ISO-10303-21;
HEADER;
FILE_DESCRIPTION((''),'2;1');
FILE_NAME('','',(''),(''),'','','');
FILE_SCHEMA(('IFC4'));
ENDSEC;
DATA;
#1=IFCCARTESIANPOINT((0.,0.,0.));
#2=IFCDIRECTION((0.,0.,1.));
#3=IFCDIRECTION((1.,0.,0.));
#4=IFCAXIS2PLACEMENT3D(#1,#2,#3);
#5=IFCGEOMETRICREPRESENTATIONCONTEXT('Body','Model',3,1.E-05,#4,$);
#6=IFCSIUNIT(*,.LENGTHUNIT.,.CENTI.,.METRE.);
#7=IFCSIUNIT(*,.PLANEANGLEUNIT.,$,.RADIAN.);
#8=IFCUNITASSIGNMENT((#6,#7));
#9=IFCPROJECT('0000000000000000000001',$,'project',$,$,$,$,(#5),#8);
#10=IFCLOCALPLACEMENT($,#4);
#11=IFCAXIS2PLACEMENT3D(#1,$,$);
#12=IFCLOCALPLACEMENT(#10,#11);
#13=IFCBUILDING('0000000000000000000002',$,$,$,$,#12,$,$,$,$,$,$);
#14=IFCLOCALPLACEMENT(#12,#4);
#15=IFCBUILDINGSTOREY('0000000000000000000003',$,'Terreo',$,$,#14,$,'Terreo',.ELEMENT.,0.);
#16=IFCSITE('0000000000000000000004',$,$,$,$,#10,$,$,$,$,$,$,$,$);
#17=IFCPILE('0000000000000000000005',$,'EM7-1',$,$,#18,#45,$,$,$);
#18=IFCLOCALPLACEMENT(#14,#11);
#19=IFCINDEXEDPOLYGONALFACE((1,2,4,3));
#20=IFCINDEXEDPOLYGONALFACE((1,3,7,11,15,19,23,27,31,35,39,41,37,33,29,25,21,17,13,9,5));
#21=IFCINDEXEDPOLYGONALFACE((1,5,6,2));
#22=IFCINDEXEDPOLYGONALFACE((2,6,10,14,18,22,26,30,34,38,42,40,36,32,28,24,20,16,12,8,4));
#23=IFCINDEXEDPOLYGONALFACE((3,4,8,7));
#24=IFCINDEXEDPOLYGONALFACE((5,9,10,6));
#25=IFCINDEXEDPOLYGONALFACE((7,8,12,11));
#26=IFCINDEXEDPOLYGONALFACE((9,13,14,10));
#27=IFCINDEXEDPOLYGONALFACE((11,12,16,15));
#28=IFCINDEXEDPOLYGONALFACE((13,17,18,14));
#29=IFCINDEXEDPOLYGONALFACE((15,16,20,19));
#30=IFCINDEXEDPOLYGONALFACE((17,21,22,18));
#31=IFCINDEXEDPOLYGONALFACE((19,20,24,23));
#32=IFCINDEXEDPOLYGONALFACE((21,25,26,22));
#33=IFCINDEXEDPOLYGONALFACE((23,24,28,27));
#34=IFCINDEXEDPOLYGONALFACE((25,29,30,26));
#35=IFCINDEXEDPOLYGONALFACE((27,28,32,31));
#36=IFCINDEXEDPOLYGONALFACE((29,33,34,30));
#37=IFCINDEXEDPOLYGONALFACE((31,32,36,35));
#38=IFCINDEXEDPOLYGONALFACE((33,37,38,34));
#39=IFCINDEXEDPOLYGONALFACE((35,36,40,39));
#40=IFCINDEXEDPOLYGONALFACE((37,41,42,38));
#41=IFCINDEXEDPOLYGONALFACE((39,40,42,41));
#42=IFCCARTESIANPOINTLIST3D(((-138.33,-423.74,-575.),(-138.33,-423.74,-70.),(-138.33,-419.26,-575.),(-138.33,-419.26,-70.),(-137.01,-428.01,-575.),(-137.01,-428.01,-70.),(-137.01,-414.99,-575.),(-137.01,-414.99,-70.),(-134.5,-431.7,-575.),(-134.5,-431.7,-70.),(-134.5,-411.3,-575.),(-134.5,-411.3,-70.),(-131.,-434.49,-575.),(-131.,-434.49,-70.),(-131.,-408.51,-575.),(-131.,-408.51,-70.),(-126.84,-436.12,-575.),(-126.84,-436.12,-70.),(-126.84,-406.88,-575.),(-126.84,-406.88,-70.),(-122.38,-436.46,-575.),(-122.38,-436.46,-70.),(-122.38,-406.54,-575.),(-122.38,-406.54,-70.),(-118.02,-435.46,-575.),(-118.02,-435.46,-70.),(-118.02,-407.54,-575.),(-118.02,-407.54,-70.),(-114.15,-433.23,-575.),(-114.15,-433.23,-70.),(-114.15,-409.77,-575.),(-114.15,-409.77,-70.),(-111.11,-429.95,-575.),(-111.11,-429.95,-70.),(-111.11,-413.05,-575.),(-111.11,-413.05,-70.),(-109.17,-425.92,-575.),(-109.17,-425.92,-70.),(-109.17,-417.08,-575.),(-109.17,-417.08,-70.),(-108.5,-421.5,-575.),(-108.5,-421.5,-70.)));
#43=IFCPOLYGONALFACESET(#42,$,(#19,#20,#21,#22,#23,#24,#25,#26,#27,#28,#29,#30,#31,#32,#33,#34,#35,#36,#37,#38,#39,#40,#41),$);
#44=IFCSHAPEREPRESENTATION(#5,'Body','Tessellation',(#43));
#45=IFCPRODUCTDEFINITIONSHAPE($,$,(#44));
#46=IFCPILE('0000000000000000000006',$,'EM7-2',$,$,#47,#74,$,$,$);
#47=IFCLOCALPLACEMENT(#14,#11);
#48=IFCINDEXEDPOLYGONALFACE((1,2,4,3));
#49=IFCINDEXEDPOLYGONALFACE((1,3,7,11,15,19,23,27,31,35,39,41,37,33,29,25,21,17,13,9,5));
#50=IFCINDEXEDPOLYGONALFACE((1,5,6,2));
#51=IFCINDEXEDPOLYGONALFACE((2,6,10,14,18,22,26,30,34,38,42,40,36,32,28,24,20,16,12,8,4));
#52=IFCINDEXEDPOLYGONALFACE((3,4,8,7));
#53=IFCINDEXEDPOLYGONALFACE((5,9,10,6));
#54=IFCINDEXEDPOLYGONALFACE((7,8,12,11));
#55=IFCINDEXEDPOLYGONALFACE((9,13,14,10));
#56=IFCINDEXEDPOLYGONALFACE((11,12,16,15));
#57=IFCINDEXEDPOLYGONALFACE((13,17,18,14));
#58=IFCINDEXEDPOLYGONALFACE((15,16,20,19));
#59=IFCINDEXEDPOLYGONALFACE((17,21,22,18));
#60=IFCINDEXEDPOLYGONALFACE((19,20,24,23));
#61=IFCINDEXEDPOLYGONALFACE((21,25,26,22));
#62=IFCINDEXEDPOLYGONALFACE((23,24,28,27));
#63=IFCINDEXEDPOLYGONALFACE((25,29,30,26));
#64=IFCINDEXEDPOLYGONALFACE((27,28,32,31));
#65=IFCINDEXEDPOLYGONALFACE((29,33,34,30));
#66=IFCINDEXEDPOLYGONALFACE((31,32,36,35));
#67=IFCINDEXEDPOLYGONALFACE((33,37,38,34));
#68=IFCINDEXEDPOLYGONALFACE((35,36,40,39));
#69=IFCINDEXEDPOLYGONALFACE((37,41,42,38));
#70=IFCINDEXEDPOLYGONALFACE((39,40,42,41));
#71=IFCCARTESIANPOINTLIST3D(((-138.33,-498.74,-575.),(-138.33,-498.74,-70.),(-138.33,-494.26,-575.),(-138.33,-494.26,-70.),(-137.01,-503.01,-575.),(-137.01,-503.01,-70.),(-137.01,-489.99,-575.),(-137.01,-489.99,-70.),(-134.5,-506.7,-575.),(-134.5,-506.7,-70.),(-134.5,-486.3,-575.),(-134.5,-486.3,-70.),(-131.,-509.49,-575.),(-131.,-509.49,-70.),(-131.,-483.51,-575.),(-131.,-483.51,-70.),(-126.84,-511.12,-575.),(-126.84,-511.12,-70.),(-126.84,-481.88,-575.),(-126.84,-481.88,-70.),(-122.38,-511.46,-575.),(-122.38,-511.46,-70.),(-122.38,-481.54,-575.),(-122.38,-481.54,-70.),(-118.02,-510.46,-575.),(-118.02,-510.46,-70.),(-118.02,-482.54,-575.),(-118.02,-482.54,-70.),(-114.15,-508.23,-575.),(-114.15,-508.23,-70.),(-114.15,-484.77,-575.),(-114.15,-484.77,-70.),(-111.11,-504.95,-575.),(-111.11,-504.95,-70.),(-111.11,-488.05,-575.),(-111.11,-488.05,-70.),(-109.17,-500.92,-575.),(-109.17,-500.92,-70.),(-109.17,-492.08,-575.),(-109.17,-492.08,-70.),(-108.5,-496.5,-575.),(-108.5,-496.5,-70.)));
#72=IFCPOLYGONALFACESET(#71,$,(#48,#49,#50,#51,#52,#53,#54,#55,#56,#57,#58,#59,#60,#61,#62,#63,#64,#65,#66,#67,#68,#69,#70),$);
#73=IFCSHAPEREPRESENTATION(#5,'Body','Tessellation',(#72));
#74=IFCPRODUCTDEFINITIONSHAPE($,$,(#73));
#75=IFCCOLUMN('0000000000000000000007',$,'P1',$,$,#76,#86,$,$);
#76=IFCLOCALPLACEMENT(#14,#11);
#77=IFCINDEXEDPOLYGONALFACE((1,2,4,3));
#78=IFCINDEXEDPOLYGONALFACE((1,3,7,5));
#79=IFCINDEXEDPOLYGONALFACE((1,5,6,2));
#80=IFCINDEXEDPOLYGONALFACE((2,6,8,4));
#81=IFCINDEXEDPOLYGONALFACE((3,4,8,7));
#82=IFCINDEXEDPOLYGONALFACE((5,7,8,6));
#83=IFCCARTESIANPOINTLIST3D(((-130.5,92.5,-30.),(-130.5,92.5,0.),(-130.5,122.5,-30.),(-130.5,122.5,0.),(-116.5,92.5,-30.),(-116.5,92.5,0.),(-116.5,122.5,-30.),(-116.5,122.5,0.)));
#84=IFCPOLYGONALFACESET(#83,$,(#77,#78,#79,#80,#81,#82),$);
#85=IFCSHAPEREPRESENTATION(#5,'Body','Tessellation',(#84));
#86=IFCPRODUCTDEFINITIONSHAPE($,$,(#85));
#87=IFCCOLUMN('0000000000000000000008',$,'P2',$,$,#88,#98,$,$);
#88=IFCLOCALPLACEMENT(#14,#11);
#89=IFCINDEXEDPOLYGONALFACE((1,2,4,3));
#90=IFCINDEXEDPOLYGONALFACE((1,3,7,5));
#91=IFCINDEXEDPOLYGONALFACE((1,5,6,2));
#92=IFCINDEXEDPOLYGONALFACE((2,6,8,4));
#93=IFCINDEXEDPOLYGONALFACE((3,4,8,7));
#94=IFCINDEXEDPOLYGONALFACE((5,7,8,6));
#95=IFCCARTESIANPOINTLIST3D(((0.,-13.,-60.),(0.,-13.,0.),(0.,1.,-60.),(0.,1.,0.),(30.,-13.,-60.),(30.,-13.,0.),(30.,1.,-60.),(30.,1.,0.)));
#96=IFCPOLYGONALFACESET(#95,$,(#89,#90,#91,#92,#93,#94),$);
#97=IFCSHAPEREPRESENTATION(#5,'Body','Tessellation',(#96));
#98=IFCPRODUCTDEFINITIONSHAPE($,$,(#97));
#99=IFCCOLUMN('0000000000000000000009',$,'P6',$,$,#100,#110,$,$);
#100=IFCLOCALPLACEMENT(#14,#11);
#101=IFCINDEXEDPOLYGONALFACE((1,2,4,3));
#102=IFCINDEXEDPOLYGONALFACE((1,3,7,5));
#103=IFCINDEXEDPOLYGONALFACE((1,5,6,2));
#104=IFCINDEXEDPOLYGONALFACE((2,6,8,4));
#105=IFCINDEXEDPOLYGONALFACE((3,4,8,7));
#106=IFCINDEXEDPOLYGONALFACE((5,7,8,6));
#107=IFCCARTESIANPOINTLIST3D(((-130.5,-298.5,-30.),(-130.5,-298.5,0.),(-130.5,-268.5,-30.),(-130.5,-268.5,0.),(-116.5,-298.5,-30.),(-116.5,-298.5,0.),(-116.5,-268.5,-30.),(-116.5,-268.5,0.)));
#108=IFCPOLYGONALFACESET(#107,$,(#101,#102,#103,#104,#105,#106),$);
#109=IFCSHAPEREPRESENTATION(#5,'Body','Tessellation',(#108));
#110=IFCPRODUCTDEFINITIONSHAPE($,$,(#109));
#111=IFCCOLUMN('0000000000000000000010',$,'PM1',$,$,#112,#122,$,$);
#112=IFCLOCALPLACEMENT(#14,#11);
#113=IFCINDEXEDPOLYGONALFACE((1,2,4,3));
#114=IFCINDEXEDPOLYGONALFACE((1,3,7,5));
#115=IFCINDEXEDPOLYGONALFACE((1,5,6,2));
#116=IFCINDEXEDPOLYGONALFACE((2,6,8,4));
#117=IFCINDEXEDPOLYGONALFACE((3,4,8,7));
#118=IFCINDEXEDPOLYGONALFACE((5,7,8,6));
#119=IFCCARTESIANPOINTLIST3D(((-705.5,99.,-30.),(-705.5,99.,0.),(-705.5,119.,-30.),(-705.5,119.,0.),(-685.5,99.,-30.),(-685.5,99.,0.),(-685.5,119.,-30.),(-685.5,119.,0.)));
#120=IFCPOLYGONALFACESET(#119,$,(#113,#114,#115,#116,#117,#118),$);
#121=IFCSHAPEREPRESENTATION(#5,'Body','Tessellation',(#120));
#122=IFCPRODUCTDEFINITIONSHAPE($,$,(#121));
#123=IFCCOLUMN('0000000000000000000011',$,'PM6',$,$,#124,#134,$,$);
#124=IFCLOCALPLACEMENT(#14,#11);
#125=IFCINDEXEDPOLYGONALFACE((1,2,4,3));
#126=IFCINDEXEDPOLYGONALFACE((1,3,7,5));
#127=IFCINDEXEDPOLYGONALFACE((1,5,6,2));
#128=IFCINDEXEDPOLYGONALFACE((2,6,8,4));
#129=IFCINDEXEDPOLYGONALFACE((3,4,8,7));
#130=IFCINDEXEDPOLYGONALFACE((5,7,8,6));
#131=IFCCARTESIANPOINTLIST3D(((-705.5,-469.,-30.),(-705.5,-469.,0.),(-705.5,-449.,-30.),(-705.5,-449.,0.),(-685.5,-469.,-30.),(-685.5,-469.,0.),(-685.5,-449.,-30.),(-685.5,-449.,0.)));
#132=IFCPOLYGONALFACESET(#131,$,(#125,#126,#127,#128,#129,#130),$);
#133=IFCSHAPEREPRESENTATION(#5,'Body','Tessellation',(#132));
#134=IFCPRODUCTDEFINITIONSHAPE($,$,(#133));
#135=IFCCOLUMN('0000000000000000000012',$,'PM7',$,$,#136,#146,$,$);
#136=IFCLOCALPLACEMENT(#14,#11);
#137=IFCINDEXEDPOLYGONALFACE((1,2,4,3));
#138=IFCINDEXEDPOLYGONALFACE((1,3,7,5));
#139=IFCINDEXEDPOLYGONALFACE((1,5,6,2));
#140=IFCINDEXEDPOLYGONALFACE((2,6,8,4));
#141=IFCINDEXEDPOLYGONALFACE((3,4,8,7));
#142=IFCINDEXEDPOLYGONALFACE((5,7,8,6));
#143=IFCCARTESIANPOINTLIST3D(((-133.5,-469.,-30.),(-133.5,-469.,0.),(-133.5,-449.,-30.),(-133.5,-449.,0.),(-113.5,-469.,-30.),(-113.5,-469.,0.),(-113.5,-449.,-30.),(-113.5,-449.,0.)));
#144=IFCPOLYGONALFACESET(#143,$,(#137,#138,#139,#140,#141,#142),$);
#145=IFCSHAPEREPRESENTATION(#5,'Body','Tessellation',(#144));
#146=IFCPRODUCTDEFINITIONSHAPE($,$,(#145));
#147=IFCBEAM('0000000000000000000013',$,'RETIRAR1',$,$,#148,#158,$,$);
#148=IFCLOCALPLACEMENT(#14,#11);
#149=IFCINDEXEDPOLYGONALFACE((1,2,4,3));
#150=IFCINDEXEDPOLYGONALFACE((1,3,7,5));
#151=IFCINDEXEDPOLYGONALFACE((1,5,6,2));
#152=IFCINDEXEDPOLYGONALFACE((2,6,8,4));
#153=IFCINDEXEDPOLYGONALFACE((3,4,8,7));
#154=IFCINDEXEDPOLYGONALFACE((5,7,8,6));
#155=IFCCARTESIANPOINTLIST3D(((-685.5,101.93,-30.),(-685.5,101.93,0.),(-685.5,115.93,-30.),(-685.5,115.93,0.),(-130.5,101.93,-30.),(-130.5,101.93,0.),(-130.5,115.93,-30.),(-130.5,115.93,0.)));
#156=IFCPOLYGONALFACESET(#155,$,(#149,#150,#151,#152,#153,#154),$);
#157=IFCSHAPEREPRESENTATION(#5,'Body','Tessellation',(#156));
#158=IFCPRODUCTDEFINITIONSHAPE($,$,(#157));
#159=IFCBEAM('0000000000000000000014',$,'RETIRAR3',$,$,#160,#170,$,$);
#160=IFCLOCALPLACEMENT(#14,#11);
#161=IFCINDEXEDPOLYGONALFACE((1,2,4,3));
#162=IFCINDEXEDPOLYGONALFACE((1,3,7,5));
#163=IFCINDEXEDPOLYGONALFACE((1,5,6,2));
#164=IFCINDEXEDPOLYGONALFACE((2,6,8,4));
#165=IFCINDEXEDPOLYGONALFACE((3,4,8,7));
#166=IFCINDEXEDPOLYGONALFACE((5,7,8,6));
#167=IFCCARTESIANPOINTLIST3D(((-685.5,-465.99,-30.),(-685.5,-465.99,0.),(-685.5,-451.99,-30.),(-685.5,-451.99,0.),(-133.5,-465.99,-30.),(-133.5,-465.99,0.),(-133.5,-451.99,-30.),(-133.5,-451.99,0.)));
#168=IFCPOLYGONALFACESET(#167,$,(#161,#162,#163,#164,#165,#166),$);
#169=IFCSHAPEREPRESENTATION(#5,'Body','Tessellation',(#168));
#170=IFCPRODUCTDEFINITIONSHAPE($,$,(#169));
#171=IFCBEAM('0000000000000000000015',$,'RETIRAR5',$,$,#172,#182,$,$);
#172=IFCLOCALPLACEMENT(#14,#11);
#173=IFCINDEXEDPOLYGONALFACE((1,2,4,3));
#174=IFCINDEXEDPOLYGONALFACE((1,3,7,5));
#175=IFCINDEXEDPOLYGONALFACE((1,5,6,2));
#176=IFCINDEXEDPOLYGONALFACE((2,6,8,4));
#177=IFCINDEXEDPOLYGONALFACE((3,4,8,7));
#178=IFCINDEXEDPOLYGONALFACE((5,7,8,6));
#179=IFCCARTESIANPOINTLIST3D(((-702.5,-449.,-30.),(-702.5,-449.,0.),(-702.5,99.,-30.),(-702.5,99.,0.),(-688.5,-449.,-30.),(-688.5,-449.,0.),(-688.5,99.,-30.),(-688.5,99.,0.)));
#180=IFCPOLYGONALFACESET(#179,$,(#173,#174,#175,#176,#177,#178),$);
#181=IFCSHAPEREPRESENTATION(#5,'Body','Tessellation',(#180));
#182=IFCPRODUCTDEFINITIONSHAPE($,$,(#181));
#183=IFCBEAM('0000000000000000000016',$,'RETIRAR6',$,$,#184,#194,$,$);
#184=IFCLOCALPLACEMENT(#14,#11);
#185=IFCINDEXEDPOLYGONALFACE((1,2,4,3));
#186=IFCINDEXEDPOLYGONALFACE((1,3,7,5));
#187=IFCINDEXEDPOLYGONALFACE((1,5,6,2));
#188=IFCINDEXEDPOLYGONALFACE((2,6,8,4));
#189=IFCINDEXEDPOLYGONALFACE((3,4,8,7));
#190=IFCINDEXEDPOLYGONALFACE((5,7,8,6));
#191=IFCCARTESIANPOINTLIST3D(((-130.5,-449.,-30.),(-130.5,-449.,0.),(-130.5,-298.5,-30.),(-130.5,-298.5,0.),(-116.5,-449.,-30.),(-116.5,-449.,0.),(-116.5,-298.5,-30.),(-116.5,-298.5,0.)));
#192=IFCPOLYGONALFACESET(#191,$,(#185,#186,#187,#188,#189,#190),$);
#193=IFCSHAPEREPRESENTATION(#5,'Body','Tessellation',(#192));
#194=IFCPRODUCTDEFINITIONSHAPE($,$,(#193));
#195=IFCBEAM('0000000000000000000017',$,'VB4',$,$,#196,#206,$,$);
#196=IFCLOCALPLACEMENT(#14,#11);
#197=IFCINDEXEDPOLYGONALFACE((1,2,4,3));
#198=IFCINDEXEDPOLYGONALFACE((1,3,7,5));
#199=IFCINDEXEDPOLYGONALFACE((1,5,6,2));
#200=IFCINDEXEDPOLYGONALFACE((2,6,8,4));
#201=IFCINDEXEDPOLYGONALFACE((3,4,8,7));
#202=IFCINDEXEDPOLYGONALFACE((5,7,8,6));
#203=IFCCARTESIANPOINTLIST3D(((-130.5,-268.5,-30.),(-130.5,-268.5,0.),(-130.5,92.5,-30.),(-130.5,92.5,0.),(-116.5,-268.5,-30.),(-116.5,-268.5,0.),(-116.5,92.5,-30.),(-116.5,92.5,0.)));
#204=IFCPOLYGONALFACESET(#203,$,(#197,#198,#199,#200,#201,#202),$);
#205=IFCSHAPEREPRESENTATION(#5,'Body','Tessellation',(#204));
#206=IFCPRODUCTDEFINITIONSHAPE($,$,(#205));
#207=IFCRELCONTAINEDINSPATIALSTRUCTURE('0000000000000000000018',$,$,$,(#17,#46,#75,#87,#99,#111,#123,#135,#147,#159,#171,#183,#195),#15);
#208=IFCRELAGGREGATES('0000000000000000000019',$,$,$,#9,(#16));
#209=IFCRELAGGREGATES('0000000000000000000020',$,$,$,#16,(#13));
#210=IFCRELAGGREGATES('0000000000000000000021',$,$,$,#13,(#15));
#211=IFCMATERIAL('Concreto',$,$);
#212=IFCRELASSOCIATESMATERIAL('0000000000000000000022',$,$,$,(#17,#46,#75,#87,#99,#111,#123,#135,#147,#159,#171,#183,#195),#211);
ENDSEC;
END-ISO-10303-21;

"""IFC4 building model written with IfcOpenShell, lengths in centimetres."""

from ifc_helpers import new_model, si_unit, frame, origin, origin_with_axes, origin_2d_with_axis, place, context, project, spatial, rectangle, circle, extrude, material, element, save


model = new_model("IFC4")

# Units and contexts
model_context = context("Model", 3, precision=1e-05, world=origin_with_axes(), identifier="Body")
ifc_project = project(units=[si_unit("LENGTHUNIT", "METRE", prefix="CENTI"), si_unit("PLANEANGLEUNIT", "RADIAN")], contexts=[model_context])

# Site, building, storey
site_placement = place(None, origin_with_axes())
site = spatial("IfcSite", under=ifc_project, at=site_placement)
building_placement = place(site_placement, origin())
building = spatial("IfcBuilding", under=site, at=building_placement)
storey_placement = place(building_placement, origin_with_axes())
storey = spatial("IfcBuildingStorey", under=building, at=storey_placement, Name="Terreo", LongName="Terreo", CompositionType="ELEMENT", Elevation=0.0)

# Piles
ifc_material = material(Name="Concreto")
for number, where, z_axis, x_axis, name in (
    (1, (-123.5, -421.5, -70.0), (0.0, 0.0, 1.0), (1.0, 0.0, 0.0), "EM7-1"),
    (2, (-123.5, -496.5, -70.0), (0.0, 0.0, 1.0), (1.0, 0.0, 0.0), "EM7-2"),
):
    element("IfcPile", number, at=place(storey_placement, frame(where, z_axis=z_axis, x_axis=x_axis)), inside=storey, material=ifc_material, Name=name, context=model_context, shape_type="SweptSolid", body=[
        extrude(circle(Radius=15.0, at=origin_2d_with_axis()), frame((0.0, 0.0, -505.0), z_axis=(0.0, 0.0, 1.0), x_axis=(1.0, 0.0, 0.0)), (0.0, 0.0, 1.0), 505.0),
    ])

# Columns
column_1_placement = place(storey_placement, frame((-123.5, 107.5, 0.0), z_axis=(0.0, 0.0, 1.0), x_axis=(1.0, 0.0, 0.0)))
element("IfcColumn", 3, at=column_1_placement, inside=storey, material=ifc_material, Name="P1", context=model_context, shape_type="SolidModel", body=[
    extrude(rectangle(XDim=14.0, YDim=30.0, at=origin_2d_with_axis()), frame((0.0, 0.0, -30.0), z_axis=(0.0, 0.0, 1.0), x_axis=(1.0, 0.0, 0.0)), (0.0, 0.0, 1.0), 30.0),
])
column_2_placement = place(storey_placement, frame((15.0, -6.0, 0.0), z_axis=(0.0, 0.0, 1.0), x_axis=(1.0, 0.0, 0.0)))
element("IfcColumn", 4, at=column_2_placement, inside=storey, material=ifc_material, Name="P2", context=model_context, shape_type="SolidModel", body=[
    extrude(rectangle(XDim=14.0, YDim=30.0, at=origin_2d_with_axis()), frame((0.0, 0.0, -60.0), z_axis=(0.0, 0.0, 1.0), x_axis=(0.0, 1.0, 0.0)), (0.0, 0.0, 1.0), 60.0),
])
column_3_placement = place(storey_placement, frame((-123.5, -283.5, 0.0), z_axis=(0.0, 0.0, 1.0), x_axis=(1.0, 0.0, 0.0)))
element("IfcColumn", 5, at=column_3_placement, inside=storey, material=ifc_material, Name="P6", context=model_context, shape_type="SolidModel", body=[
    extrude(rectangle(XDim=14.0, YDim=30.0, at=origin_2d_with_axis()), frame((0.0, 0.0, -30.0), z_axis=(0.0, 0.0, 1.0), x_axis=(1.0, 0.0, 0.0)), (0.0, 0.0, 1.0), 30.0),
])
column_4_placement = place(storey_placement, frame((-695.5, 109.0, 0.0), z_axis=(0.0, 0.0, 1.0), x_axis=(1.0, 0.0, 0.0)))
element("IfcColumn", 6, at=column_4_placement, inside=storey, material=ifc_material, Name="PM1", context=model_context, shape_type="SolidModel", body=[
    extrude(rectangle(XDim=20.0, YDim=20.0, at=origin_2d_with_axis()), frame((0.0, 0.0, -30.0), z_axis=(0.0, 0.0, 1.0), x_axis=(1.0, 0.0, 0.0)), (0.0, 0.0, 1.0), 30.0),
])
for number, where, z_axis, x_axis, name in (
    (7, (-695.5, -459.0, 0.0), (0.0, 0.0, 1.0), (1.0, 0.0, 0.0), "PM6"),
    (8, (-123.5, -459.0, 0.0), (0.0, 0.0, 1.0), (1.0, 0.0, 0.0), "PM7"),
):
    element("IfcColumn", number, at=place(storey_placement, frame(where, z_axis=z_axis, x_axis=x_axis)), inside=storey, material=ifc_material, Name=name, context=model_context, shape_type="SolidModel", body=[
        extrude(rectangle(XDim=20.0, YDim=20.0, at=origin_2d_with_axis()), frame((0.0, 0.0, -30.0), z_axis=(0.0, 0.0, 1.0), x_axis=(0.0, 1.0, 0.0)), (0.0, 0.0, 1.0), 30.0),
    ])

# Beams
beam_1_placement = place(storey_placement, frame((-408.0, 108.93, 0.0), z_axis=(0.0, 0.0, 1.0), x_axis=(1.0, 0.0, 0.0)))
element("IfcBeam", 9, at=beam_1_placement, inside=storey, material=ifc_material, Name="RETIRAR1", context=model_context, shape_type="SolidModel", body=[
    extrude(rectangle(XDim=14.0, YDim=30.0, at=origin_2d_with_axis()), frame((-277.5, 0.0, -15.0), z_axis=(1.0, 0.0, 0.0), x_axis=(0.0, -1.0, 0.0)), (0.0, 0.0, 1.0), 555.0),
])
beam_2_placement = place(storey_placement, frame((-409.5, -458.99, 0.0), z_axis=(0.0, 0.0, 1.0), x_axis=(1.0, 0.0, 0.0)))
element("IfcBeam", 10, at=beam_2_placement, inside=storey, material=ifc_material, Name="RETIRAR3", context=model_context, shape_type="SolidModel", body=[
    extrude(rectangle(XDim=14.0, YDim=30.0, at=origin_2d_with_axis()), frame((-276.0, 0.0, -15.0), z_axis=(1.0, 0.0, 0.0), x_axis=(0.0, -1.0, 0.0)), (0.0, 0.0, 1.0), 552.0),
])
beam_3_placement = place(storey_placement, frame((-695.5, -175.0, 0.0), z_axis=(0.0, 0.0, 1.0), x_axis=(1.0, 0.0, 0.0)))
element("IfcBeam", 11, at=beam_3_placement, inside=storey, material=ifc_material, Name="RETIRAR5", context=model_context, shape_type="SolidModel", body=[
    extrude(rectangle(XDim=14.0, YDim=30.0, at=origin_2d_with_axis()), frame((0.0, -274.0, -15.0), z_axis=(0.0, 1.0, 0.0), x_axis=(-1.0, 0.0, 0.0)), (0.0, 0.0, 1.0), 548.0),
])
beam_4_placement = place(storey_placement, frame((-123.5, -373.75, 0.0), z_axis=(0.0, 0.0, 1.0), x_axis=(1.0, 0.0, 0.0)))
element("IfcBeam", 12, at=beam_4_placement, inside=storey, material=ifc_material, Name="RETIRAR6", context=model_context, shape_type="SolidModel", body=[
    extrude(rectangle(XDim=14.0, YDim=30.0, at=origin_2d_with_axis()), frame((0.0, -75.25, -15.0), z_axis=(0.0, 1.0, 0.0), x_axis=(1.0, 0.0, 0.0)), (0.0, 0.0, 1.0), 150.5),
])
beam_5_placement = place(storey_placement, frame((-123.5, -88.0, 0.0), z_axis=(0.0, 0.0, 1.0), x_axis=(1.0, 0.0, 0.0)))
element("IfcBeam", 13, at=beam_5_placement, inside=storey, material=ifc_material, Name="VB4", context=model_context, shape_type="SolidModel", body=[
    extrude(rectangle(XDim=14.0, YDim=30.0, at=origin_2d_with_axis()), frame((0.0, -180.5, -15.0), z_axis=(0.0, 1.0, 0.0), x_axis=(1.0, 0.0, 0.0)), (0.0, 0.0, 1.0), 361.0),
])

save(model, "model.ifc")
